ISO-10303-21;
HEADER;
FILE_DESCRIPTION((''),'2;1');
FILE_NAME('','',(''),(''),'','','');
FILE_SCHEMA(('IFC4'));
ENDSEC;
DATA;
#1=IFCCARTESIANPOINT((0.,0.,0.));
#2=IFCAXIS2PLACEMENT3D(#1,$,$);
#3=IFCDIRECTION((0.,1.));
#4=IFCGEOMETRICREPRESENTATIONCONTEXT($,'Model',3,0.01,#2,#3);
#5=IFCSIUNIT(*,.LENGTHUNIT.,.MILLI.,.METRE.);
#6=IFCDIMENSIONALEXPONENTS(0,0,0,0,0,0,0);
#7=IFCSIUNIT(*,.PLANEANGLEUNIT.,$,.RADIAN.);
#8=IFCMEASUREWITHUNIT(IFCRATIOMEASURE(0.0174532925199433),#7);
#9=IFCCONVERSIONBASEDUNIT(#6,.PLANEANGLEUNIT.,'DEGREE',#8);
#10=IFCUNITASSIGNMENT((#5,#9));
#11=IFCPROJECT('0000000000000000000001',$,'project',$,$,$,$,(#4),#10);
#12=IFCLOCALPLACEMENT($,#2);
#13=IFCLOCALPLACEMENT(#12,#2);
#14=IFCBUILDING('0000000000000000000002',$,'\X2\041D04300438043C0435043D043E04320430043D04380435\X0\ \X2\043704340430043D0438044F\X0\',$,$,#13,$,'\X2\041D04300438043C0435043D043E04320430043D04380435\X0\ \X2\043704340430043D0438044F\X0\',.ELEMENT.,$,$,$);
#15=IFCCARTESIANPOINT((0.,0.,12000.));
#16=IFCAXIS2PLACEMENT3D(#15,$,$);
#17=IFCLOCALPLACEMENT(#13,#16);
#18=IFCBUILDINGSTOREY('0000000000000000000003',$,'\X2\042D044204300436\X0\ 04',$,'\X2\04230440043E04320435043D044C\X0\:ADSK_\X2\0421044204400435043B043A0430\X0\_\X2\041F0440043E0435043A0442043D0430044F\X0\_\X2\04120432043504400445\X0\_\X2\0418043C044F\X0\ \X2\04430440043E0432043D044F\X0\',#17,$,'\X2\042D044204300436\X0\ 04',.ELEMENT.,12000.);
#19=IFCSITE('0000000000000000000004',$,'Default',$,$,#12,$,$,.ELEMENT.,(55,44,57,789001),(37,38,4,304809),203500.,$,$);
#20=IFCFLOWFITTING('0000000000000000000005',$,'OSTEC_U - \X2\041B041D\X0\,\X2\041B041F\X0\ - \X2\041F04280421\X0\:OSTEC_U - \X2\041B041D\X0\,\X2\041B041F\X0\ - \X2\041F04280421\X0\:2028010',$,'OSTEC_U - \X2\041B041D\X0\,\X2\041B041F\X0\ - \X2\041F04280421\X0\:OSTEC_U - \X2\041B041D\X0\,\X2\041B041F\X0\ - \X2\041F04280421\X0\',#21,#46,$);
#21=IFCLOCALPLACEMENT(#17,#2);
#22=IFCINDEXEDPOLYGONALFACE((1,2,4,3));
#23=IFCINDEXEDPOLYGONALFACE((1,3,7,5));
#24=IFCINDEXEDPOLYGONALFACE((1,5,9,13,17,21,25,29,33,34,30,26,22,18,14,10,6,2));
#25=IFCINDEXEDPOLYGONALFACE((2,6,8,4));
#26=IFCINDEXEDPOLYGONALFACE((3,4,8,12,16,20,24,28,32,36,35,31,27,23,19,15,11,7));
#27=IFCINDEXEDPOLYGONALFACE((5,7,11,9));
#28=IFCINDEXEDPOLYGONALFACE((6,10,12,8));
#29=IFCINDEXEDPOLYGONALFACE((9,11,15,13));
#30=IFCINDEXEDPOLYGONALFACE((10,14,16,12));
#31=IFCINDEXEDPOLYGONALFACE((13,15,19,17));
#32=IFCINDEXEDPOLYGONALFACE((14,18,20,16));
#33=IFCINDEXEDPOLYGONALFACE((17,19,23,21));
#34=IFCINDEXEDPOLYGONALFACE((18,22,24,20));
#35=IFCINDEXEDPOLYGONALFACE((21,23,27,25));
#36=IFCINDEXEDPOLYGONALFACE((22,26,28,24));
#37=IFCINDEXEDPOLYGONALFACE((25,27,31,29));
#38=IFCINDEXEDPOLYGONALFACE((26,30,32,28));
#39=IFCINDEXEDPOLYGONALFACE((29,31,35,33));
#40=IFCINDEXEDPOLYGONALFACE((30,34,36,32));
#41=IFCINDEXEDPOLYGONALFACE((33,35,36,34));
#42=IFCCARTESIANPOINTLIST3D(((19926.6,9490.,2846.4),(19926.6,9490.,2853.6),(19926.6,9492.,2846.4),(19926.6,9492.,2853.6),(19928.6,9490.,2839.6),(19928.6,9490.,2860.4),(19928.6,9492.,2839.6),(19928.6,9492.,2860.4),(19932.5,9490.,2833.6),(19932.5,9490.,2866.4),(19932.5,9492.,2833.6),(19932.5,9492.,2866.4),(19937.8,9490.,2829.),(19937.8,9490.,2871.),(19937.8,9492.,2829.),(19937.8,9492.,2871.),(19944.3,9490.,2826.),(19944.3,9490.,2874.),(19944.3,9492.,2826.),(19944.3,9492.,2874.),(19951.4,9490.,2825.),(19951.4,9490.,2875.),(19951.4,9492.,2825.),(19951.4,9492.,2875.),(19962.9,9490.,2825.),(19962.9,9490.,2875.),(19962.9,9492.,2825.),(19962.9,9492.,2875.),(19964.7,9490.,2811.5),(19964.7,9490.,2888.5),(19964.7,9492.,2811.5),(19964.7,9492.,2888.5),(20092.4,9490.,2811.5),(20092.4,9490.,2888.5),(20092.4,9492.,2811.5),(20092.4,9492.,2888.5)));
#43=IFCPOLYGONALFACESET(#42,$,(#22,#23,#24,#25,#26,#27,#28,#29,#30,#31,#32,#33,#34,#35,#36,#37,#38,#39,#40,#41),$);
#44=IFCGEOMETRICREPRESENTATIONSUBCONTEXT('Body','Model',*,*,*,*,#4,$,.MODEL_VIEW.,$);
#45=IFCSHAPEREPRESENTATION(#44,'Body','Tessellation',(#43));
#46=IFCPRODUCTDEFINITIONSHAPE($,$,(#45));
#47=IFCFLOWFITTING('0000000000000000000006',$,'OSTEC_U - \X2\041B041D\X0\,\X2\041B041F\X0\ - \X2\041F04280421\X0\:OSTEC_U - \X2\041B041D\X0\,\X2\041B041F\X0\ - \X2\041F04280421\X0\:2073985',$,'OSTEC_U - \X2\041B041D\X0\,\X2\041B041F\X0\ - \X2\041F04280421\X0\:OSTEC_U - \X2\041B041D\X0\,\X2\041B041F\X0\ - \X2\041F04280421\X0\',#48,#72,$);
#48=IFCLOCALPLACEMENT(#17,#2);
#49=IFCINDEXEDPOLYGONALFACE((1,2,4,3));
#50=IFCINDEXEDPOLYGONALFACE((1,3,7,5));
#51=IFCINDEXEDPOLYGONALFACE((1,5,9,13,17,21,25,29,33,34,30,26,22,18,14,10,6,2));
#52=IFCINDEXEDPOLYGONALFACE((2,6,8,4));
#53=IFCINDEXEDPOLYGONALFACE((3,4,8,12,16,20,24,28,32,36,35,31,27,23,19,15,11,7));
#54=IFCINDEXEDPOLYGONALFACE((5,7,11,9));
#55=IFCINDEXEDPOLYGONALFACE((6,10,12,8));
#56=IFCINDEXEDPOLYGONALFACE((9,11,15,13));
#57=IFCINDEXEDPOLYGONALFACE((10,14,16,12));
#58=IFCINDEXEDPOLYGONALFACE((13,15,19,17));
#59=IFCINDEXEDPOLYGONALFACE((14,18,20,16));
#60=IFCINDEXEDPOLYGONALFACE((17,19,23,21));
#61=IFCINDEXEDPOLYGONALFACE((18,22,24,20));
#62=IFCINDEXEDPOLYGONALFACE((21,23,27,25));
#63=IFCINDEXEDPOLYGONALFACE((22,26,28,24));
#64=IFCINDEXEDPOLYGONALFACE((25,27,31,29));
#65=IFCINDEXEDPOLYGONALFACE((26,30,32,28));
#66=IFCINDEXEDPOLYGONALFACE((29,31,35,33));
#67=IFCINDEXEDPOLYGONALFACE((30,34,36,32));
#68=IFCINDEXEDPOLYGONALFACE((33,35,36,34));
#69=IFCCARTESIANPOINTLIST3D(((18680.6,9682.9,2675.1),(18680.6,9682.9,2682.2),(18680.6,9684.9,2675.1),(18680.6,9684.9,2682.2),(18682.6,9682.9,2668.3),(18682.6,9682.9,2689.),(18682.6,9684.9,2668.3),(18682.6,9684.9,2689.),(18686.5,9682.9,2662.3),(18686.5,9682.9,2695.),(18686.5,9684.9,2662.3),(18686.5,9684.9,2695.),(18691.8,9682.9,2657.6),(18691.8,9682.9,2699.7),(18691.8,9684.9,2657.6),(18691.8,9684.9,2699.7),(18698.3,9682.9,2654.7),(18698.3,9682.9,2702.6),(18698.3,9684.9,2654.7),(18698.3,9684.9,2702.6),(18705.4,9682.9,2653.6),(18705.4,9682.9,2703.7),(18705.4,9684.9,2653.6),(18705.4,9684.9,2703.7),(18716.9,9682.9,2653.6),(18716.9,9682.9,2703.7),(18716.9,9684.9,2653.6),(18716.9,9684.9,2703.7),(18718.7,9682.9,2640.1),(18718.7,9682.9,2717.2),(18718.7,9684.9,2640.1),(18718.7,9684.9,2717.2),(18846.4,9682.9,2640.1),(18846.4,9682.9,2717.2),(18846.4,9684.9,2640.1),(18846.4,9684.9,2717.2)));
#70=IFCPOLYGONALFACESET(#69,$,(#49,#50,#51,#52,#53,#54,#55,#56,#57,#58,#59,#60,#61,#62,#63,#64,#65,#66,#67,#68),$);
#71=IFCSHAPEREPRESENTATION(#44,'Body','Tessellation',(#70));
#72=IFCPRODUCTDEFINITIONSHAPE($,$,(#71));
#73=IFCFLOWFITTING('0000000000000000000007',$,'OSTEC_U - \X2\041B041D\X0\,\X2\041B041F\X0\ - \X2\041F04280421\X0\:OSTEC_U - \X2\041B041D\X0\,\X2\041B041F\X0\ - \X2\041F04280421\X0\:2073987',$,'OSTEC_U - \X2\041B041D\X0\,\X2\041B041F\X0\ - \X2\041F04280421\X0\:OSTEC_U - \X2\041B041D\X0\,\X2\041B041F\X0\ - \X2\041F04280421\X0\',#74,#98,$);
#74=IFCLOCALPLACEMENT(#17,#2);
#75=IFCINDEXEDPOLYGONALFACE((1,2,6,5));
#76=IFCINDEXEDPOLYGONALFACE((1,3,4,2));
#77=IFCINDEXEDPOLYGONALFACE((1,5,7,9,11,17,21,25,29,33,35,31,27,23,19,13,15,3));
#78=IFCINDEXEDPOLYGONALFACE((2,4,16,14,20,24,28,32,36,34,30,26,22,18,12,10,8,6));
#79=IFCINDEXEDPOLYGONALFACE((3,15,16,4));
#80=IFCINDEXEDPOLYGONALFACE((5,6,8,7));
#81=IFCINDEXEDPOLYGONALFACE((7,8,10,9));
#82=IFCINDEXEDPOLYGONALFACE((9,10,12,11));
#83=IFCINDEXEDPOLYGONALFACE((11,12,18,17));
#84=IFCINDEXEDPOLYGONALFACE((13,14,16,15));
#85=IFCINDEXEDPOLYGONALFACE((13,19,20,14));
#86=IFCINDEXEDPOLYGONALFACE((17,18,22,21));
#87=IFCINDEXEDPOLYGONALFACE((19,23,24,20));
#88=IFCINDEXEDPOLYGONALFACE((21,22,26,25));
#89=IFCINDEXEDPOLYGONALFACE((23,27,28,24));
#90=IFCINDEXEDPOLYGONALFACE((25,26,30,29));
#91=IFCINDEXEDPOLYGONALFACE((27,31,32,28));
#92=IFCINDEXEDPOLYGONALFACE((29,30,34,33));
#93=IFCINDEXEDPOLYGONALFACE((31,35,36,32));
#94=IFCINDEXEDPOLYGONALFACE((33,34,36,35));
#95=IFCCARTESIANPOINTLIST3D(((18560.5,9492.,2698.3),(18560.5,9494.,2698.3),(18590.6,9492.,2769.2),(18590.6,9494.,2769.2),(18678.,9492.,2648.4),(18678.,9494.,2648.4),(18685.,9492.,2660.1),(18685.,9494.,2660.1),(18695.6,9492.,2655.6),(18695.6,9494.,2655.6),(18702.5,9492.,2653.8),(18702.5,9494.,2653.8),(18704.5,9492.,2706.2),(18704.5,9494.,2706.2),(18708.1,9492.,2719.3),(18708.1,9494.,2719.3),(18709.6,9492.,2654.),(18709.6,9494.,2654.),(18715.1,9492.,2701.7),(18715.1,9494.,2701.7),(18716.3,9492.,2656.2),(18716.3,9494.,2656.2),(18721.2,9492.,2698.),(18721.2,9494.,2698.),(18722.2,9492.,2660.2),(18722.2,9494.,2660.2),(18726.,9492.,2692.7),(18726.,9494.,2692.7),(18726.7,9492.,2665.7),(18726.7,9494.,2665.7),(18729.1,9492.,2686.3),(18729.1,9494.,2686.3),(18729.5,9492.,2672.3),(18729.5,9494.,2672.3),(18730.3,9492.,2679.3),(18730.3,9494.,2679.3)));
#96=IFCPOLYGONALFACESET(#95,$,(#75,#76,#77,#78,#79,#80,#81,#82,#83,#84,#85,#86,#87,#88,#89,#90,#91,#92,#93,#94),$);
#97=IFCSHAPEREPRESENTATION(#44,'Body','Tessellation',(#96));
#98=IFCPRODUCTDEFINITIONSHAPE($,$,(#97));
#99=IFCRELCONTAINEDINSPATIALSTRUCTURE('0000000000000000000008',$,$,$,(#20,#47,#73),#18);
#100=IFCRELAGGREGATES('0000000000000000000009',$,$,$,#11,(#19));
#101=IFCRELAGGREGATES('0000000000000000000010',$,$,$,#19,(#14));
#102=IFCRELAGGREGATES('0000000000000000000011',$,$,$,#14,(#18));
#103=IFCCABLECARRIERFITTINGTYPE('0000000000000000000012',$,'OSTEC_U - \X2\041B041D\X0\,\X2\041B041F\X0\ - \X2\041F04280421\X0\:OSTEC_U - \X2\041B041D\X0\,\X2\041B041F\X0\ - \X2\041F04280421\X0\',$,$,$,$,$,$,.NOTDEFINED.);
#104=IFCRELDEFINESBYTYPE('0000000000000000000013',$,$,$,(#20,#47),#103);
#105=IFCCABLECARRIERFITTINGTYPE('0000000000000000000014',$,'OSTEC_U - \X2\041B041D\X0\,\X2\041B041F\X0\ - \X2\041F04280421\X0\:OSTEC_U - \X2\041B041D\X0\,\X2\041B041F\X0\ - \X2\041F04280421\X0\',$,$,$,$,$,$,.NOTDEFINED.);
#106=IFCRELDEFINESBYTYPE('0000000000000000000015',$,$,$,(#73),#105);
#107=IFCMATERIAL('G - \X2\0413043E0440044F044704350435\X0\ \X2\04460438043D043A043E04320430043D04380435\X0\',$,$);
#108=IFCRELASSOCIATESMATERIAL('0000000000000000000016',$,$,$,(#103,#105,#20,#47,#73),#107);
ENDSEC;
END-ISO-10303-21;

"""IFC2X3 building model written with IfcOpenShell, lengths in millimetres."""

from ifc_helpers import new_model, entity, si_unit, converted_unit, direction, frame, frame_2d, origin, place, context, subcontext, project, spatial, polyline, circle_curve, parameter, trimmed, segment, composite_curve, outline, extrude, source, transform, mapped, material, type_object, type_shapes, element, save


model = new_model("IFC2X3")

# Units and contexts
model_context = context("Model", 3, precision=0.01, world=origin(), true_north=direction((0.0, 1.0)))
body_context = subcontext(model_context, "Body", "Model", "MODEL_VIEW")
ifc_project = project(units=[si_unit("LENGTHUNIT", "METRE", prefix="MILLI"), converted_unit("PLANEANGLEUNIT", "DEGREE", entity("IfcRatioMeasure", 0.0174532925199433), si_unit("PLANEANGLEUNIT", "RADIAN"), dimensions=[0, 0, 0, 0, 0, 0, 0])], contexts=[model_context])

# Site, building, storey
site_placement = place(None, origin())
site = spatial("IfcSite", under=ifc_project, at=site_placement, Name="Default", CompositionType="ELEMENT", RefLatitude=(55, 44, 57, 789001), RefLongitude=(37, 38, 4, 304809), RefElevation=203500.0)
building_placement = place(site_placement, origin())
building = spatial("IfcBuilding", under=site, at=building_placement, Name="Наименование здания", LongName="Наименование здания", CompositionType="ELEMENT")
storey_placement = place(building_placement, frame((0.0, 0.0, 12000.0)))
storey = spatial("IfcBuildingStorey", under=building, at=storey_placement, Name="Этаж 04", ObjectType="Уровень:ADSK_Стрелка_Проектная_Вверх_Имя уровня", LongName="Этаж 04", CompositionType="ELEMENT", Elevation=12000.0)

# Flow fittings
ifc_material = material(Name="G - Горячее цинкование")
cable_carrier_fitting_type_1 = type_object("IfcCableCarrierFittingType", Name="OSTEC_U - ЛН,ЛП - ПШС:OSTEC_U - ЛН,ЛП - ПШС", PredefinedType="NOTDEFINED", material=ifc_material)
shared_shape_1 = source(origin(), body_context, "Body", "SweptSolid", [
    extrude(outline(composite_curve([segment(trimmed(circle_curve(frame_2d((-41.5, 0.0), x_axis=(1.0, 0.0)), 25.0), [parameter(90.0)], [parameter(270.0)], True, "PARAMETER"), True, "CONTINUOUS"), segment(polyline([(-41.5, -25.0), (-30.0, -25.0)]), True, "CONTINUOUS"), segment(polyline([(-30.0, -25.0), (-28.1, -38.5)]), True, "CONTINUOUS"), segment(polyline([(-28.1, -38.5), (99.5, -38.5)]), True, "CONTINUOUS"), segment(polyline([(99.5, -38.5), (99.5, 38.5)]), True, "CONTINUOUS"), segment(polyline([(99.5, 38.5), (-28.1, 38.5)]), True, "CONTINUOUS"), segment(polyline([(-28.1, 38.5), (-30.0, 25.0)]), True, "CONTINUOUS"), segment(polyline([(-30.0, 25.0), (-41.5, 25.0)]), True, "CONTINUOUS")], self_intersect=False)), frame((41.5, 0.0, 0.0)), (0.0, 0.0, 1.0), 2.0),
])
type_shapes(cable_carrier_fitting_type_1, [shared_shape_1])
cable_carrier_fitting_type_2 = type_object("IfcCableCarrierFittingType", Name="OSTEC_U - ЛН,ЛП - ПШС:OSTEC_U - ЛН,ЛП - ПШС", PredefinedType="NOTDEFINED", material=ifc_material)
type_shapes(cable_carrier_fitting_type_2, [shared_shape_1])
for number, where, z_axis, x_axis, name in (
    (1, (19951.4, 9492.0, 2850.0), (0.0, -1.0, 0.0), (1.0, 0.0, 0.0), "OSTEC_U - ЛН,ЛП - ПШС:OSTEC_U - ЛН,ЛП - ПШС:2028010"),
    (2, (18705.3, 9682.9, 2678.7), (0.0, 1.0, 0.0), (1.0, 0.0, 0.0), "OSTEC_U - ЛН,ЛП - ПШС:OSTEC_U - ЛН,ЛП - ПШС:2073985"),
):
    element("IfcFlowFitting", number, at=place(storey_placement, frame(where, z_axis=z_axis, x_axis=x_axis)), inside=storey, type_object=cable_carrier_fitting_type_1, material=ifc_material, Name=name, ObjectType="OSTEC_U - ЛН,ЛП - ПШС:OSTEC_U - ЛН,ЛП - ПШС", context=body_context, shape_type="MappedRepresentation", body=[
        mapped(shared_shape_1, transform((0.0, 0.0, 0.0), scale=1.0)),
    ])
flow_fitting_1_placement = place(storey_placement, frame((18705.3, 9494.0, 2678.7), z_axis=(0.0, -1.0, 0.0), x_axis=(-0.920505, 0.0, 0.390731)))
element("IfcFlowFitting", 3, at=flow_fitting_1_placement, inside=storey, type_object=cable_carrier_fitting_type_2, material=ifc_material, Name="OSTEC_U - ЛН,ЛП - ПШС:OSTEC_U - ЛН,ЛП - ПШС:2073987", ObjectType="OSTEC_U - ЛН,ЛП - ПШС:OSTEC_U - ЛН,ЛП - ПШС", context=body_context, shape_type="MappedRepresentation", body=[
    mapped(shared_shape_1, transform((0.0, 0.0, 0.0), scale=1.0)),
])

save(model, "model.ifc")
